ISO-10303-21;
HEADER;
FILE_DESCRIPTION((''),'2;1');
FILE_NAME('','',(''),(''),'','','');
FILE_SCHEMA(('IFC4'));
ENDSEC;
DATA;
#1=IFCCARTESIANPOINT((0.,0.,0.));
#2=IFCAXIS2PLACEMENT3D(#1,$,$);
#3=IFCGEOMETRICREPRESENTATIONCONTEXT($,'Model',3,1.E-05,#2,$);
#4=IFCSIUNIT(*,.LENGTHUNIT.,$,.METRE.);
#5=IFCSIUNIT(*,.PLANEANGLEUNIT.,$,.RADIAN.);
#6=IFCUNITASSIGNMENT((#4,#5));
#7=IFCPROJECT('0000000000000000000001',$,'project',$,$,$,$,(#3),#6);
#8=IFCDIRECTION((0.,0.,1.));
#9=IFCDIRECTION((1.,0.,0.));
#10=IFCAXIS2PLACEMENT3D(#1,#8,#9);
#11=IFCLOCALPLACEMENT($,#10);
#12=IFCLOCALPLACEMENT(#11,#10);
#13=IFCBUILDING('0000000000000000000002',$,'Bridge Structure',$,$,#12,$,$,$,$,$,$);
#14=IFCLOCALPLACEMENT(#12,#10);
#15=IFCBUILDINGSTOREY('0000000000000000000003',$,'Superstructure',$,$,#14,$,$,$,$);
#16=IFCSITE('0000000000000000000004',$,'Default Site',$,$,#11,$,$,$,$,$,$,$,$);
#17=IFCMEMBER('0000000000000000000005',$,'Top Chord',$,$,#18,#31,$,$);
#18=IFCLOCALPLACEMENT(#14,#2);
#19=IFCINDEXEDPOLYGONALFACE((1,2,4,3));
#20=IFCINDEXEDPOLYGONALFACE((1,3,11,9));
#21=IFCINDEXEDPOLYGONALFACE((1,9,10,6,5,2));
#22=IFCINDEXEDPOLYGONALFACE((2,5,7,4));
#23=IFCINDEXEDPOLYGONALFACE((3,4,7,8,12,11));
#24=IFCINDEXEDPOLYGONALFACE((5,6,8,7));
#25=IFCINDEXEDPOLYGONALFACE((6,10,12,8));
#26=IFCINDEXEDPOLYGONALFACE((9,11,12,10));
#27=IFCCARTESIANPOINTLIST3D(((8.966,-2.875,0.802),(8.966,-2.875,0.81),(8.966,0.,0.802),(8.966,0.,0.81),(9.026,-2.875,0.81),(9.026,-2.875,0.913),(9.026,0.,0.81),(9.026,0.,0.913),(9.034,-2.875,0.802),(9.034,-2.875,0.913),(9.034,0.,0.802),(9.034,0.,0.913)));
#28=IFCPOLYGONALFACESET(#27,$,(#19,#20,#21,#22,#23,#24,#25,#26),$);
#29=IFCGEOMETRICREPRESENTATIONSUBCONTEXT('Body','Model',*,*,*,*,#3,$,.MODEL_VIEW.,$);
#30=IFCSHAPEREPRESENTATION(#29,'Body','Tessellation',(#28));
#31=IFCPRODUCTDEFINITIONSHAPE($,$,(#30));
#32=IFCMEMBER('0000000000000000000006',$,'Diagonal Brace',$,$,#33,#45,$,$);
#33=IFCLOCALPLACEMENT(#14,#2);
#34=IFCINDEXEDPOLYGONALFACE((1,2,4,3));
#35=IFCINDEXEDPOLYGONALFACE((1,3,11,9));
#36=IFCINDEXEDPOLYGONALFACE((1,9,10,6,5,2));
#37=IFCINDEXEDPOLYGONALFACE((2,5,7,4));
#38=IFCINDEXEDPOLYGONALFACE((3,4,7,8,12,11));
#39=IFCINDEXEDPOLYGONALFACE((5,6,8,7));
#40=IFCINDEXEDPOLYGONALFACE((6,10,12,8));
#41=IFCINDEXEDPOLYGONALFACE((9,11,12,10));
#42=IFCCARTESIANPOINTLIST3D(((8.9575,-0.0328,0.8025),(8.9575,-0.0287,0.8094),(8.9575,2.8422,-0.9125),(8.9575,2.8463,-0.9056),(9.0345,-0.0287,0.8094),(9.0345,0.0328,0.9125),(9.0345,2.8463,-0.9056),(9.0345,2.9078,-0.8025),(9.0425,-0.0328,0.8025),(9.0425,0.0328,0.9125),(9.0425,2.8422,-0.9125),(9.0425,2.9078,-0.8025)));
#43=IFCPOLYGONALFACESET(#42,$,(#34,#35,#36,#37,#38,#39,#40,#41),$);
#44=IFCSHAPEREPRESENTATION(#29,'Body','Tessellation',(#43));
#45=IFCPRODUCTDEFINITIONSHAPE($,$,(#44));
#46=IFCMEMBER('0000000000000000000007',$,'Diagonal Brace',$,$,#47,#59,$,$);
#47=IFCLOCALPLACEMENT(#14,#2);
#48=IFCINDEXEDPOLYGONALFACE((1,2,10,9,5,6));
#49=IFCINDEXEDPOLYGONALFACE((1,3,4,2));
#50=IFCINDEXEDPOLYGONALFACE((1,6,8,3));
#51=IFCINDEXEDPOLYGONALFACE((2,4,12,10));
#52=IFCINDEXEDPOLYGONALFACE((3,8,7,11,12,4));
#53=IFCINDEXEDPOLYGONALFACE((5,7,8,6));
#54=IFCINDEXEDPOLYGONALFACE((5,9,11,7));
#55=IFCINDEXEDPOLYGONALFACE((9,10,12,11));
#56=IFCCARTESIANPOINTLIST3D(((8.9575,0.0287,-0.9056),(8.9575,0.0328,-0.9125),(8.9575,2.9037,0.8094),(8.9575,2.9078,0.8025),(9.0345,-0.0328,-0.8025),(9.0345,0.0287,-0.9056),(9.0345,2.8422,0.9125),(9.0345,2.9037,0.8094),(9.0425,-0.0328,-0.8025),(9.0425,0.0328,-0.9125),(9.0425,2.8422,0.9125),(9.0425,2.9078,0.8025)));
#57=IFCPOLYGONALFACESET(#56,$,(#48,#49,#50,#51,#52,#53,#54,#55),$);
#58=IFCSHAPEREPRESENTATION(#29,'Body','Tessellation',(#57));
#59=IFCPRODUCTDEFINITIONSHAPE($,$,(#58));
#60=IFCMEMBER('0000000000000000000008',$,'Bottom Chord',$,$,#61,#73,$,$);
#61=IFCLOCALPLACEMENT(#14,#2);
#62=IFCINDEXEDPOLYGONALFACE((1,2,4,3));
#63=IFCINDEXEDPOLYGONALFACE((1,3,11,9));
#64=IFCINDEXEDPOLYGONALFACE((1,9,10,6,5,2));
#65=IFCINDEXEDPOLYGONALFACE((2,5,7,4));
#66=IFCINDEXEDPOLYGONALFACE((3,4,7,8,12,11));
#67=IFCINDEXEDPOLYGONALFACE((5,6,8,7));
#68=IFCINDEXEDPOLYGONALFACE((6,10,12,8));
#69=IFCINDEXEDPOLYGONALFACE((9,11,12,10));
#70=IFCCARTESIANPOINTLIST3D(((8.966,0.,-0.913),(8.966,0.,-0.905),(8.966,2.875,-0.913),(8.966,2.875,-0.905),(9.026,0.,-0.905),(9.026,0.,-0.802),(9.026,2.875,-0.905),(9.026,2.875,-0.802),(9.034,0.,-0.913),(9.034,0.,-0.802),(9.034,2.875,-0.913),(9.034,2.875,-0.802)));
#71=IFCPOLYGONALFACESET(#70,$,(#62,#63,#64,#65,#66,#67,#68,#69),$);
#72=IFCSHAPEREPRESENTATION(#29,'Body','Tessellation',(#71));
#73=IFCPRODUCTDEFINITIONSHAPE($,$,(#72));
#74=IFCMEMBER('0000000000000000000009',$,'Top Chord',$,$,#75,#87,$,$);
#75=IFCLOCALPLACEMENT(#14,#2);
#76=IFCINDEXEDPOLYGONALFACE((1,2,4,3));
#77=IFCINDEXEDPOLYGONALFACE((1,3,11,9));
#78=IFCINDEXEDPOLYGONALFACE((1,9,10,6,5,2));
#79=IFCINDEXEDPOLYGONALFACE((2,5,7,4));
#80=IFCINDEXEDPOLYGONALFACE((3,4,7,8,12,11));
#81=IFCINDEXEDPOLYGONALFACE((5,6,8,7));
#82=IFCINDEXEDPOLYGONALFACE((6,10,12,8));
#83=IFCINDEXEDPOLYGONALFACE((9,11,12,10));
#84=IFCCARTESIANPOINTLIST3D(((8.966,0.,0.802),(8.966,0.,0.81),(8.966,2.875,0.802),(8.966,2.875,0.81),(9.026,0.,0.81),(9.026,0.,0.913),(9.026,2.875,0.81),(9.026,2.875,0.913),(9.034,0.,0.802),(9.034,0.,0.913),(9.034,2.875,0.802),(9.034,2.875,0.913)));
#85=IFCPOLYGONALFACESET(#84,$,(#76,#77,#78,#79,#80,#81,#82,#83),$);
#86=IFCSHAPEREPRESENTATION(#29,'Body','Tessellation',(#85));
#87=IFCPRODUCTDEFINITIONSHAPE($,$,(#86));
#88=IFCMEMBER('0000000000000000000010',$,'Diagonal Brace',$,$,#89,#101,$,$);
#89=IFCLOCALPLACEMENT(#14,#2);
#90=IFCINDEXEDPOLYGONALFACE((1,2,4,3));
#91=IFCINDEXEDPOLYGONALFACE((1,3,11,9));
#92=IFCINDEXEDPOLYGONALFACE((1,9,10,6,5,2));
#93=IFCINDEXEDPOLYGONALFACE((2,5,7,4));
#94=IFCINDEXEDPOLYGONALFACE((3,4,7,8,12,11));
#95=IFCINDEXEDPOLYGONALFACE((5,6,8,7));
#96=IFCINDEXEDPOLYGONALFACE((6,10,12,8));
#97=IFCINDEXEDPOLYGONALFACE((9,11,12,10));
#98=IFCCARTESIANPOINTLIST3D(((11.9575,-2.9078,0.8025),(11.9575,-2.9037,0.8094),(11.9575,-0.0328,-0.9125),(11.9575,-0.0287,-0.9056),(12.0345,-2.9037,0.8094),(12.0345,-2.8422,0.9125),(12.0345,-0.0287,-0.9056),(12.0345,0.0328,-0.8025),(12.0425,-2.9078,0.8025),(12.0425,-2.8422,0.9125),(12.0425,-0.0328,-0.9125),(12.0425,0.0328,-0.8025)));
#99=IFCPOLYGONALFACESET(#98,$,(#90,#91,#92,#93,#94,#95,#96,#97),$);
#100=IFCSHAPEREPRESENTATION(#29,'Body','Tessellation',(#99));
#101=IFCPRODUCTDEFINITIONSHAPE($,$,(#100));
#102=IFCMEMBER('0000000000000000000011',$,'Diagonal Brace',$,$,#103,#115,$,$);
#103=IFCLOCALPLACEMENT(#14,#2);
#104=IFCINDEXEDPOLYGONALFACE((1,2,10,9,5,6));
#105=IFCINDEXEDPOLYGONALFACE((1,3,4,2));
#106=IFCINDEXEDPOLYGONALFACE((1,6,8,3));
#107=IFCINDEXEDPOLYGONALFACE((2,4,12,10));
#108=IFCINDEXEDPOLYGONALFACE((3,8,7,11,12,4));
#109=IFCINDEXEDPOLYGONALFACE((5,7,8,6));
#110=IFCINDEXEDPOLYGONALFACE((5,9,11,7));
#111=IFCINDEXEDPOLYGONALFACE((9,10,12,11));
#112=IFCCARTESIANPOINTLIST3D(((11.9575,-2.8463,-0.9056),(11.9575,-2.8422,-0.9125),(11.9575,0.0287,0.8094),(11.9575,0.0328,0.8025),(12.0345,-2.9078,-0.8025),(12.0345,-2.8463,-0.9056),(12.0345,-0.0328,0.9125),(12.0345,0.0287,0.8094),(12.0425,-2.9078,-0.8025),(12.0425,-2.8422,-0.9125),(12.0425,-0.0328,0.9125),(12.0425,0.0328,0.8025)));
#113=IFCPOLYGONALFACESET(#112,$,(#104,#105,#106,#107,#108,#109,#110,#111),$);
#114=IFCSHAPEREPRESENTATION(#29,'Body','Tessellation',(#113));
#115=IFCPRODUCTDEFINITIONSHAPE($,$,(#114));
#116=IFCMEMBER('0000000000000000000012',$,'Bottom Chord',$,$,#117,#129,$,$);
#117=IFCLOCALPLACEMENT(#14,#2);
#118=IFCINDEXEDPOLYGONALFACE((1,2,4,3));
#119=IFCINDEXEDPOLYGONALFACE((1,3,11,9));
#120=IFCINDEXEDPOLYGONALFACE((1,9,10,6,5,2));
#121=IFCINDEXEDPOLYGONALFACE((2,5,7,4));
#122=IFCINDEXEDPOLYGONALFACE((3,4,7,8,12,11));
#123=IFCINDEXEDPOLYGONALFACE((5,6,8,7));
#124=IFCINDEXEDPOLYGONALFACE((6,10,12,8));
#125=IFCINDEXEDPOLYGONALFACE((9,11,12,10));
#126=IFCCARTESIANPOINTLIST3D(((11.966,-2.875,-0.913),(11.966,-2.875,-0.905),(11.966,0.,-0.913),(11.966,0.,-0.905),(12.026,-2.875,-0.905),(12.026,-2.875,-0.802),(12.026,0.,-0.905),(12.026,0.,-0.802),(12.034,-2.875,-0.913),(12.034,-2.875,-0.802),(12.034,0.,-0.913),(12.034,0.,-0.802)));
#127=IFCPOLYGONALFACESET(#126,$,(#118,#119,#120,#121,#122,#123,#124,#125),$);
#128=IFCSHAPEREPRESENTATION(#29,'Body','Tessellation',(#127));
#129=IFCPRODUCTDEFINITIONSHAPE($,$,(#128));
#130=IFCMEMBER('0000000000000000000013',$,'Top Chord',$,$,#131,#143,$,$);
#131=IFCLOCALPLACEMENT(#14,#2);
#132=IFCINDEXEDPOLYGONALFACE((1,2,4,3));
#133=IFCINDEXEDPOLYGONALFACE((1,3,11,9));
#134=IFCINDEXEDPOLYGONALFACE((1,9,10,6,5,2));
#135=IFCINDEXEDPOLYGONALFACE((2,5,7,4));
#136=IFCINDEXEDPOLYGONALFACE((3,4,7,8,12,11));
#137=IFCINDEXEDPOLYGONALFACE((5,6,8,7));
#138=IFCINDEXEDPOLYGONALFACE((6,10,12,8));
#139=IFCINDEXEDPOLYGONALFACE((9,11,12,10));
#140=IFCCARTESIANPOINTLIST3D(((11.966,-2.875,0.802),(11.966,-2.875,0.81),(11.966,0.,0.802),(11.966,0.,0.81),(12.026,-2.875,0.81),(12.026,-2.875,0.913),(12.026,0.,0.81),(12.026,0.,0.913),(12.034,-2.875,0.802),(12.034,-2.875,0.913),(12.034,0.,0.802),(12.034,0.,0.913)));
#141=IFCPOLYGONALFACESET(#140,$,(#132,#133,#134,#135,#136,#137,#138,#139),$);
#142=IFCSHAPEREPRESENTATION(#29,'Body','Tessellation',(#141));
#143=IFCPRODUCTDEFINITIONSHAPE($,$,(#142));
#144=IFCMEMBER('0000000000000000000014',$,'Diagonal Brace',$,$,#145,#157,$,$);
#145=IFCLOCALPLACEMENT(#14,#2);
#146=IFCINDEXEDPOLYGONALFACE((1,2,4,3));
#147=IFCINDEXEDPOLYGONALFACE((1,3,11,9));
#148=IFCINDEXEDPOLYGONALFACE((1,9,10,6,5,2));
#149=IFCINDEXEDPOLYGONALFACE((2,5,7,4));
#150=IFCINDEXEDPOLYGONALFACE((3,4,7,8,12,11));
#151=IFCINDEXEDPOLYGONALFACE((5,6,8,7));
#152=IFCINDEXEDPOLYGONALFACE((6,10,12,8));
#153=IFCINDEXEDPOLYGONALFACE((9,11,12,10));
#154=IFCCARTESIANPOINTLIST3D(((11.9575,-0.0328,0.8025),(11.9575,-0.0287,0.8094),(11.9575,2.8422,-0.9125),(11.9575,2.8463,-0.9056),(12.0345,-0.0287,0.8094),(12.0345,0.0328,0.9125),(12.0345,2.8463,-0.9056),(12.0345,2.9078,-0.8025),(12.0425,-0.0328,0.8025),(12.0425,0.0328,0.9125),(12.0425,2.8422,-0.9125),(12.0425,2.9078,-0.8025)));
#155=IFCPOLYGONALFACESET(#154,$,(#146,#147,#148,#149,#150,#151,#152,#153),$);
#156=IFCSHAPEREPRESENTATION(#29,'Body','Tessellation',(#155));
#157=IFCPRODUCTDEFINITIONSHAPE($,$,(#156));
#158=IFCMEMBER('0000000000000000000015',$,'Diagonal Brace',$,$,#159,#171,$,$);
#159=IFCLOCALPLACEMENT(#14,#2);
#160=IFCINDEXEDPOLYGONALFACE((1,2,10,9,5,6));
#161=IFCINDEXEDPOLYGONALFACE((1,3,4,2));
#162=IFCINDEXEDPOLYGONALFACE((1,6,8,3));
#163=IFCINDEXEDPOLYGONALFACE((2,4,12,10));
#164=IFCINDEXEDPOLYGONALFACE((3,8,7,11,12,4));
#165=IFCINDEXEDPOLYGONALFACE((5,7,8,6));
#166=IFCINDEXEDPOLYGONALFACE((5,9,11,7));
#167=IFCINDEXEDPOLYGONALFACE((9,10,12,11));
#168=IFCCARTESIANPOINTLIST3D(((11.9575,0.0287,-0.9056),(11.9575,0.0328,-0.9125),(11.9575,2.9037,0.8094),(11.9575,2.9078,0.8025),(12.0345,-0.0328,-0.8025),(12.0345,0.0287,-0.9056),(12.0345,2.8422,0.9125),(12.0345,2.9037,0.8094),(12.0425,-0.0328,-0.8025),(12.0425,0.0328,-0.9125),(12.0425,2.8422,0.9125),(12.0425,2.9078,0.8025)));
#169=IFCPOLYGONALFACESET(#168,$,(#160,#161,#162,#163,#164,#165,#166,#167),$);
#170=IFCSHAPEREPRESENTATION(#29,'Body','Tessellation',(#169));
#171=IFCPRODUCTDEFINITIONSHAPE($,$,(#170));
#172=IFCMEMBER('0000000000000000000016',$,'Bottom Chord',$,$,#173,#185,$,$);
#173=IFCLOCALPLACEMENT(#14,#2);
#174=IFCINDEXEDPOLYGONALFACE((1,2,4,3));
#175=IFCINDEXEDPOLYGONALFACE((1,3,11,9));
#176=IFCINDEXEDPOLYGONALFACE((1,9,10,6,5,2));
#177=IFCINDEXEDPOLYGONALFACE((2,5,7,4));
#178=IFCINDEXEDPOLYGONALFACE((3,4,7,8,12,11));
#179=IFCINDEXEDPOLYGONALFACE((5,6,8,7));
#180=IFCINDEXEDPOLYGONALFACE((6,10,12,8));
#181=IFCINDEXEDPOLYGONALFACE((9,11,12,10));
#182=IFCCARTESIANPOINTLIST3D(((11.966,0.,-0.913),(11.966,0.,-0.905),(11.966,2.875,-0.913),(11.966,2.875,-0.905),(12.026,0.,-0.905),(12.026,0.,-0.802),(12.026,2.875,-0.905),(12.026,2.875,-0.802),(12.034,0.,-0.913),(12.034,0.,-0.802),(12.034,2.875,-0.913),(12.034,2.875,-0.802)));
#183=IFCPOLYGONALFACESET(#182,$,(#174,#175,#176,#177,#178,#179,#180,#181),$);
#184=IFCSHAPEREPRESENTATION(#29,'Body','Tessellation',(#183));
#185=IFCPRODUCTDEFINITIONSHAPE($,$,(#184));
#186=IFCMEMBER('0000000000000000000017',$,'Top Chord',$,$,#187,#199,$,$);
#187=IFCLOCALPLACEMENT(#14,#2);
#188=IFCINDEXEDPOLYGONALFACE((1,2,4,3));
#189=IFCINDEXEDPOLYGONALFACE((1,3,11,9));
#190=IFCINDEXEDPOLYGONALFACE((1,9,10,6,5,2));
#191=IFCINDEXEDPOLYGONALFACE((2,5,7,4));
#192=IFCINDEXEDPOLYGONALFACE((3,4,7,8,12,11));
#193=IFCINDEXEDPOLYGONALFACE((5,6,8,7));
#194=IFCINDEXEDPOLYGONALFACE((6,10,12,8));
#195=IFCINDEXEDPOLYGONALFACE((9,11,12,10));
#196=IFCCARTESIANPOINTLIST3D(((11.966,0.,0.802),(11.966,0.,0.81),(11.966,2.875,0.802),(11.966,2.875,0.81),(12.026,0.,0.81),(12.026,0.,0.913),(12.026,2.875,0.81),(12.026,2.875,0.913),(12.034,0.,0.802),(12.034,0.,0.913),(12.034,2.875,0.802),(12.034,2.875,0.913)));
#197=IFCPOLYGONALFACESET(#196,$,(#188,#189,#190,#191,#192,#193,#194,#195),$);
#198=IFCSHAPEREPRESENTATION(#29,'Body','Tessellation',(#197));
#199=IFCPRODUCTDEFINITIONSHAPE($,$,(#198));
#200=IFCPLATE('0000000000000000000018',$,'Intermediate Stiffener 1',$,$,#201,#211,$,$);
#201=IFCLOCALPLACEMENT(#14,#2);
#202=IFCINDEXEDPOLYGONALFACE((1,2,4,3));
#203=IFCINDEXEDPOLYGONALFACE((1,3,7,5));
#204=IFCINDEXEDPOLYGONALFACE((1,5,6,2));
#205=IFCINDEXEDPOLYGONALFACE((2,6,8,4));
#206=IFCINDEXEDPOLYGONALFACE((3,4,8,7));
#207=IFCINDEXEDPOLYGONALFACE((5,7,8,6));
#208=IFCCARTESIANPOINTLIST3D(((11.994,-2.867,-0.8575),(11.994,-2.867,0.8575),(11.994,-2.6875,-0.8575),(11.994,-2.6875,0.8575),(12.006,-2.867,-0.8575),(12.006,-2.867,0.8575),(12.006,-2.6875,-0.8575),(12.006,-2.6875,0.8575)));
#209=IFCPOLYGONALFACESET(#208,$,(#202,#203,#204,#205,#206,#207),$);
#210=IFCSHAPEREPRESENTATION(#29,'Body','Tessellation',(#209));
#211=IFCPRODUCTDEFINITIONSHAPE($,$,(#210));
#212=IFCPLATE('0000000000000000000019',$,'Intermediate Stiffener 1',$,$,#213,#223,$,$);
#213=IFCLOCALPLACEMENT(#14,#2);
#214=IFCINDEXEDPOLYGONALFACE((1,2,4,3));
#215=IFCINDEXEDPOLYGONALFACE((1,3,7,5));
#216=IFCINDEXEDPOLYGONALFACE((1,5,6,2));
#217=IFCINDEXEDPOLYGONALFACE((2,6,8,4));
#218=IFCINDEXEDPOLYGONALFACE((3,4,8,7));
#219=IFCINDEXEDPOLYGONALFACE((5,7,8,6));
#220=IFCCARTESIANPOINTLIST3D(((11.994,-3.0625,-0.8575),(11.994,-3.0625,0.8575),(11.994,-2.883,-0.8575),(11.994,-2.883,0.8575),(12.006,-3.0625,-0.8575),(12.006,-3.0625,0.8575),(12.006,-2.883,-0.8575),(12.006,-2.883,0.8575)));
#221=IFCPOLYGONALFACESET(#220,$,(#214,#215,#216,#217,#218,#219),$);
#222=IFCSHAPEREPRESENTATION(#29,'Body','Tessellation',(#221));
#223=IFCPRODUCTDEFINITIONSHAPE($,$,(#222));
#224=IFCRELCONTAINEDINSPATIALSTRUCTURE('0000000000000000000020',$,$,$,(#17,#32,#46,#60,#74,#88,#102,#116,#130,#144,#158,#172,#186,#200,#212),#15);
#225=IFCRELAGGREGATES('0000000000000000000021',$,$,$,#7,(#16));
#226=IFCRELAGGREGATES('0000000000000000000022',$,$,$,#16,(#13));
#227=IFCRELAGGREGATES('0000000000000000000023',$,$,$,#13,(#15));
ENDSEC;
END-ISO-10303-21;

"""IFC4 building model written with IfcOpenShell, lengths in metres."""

from ifc_helpers import new_model, si_unit, frame, origin, origin_with_axes, origin_2d_with_axis, place, context, subcontext, project, spatial, rectangle, l_section, extrude, element, save


model = new_model("IFC4")

# Units and contexts
model_context = context("Model", 3, precision=1e-05, world=origin())
body_context = subcontext(model_context, "Body", "Model", "MODEL_VIEW")
ifc_project = project(units=[si_unit("LENGTHUNIT", "METRE"), si_unit("PLANEANGLEUNIT", "RADIAN")], contexts=[model_context])

# Site, building, storey
site_placement = place(None, origin_with_axes())
site = spatial("IfcSite", under=ifc_project, at=site_placement, Name="Default Site")
building_placement = place(site_placement, origin_with_axes())
building = spatial("IfcBuilding", under=site, at=building_placement, Name="Bridge Structure")
storey_placement = place(building_placement, origin_with_axes())
storey = spatial("IfcBuildingStorey", under=building, at=storey_placement, Name="Superstructure")

# Members
member_placement = place(storey_placement, frame((9.0, -2.875, 0.8575), z_axis=(0.0, 1.0, 0.0), x_axis=(-1.0, 0.0, 0.0)))
element("IfcMember", 1, at=member_placement, inside=storey, Name="Top Chord", context=body_context, shape_type="SweptSolid", body=[
    extrude(l_section(Depth=0.111, Width=0.068, Thickness=0.008, at=origin_2d_with_axis()), origin_with_axes(), (0.0, 0.0, 1.0), 2.875),
])
for number, where, z_axis, x_axis, name in (
    (2, (9.0, 0.0, 0.8575), (0.0, 0.858808, -0.512298), (-1.0, 0.0, 0.0), "Diagonal Brace"),
    (3, (9.0, 0.0, -0.8575), (0.0, 0.858808, 0.512298), (-1.0, 0.0, 0.0), "Diagonal Brace"),
):
    element("IfcMember", number, at=place(storey_placement, frame(where, z_axis=z_axis, x_axis=x_axis)), inside=storey, Name=name, context=body_context, shape_type="SweptSolid", body=[
        extrude(l_section(Depth=0.128, Width=0.085, Thickness=0.008, at=origin_2d_with_axis()), origin_with_axes(), (0.0, 0.0, 1.0), 3.3477),
    ])
for number, where, z_axis, x_axis, name in (
    (4, (9.0, 0.0, -0.8575), (0.0, 1.0, 0.0), (-1.0, 0.0, 0.0), "Bottom Chord"),
    (5, (9.0, 0.0, 0.8575), (0.0, 1.0, 0.0), (-1.0, 0.0, 0.0), "Top Chord"),
):
    element("IfcMember", number, at=place(storey_placement, frame(where, z_axis=z_axis, x_axis=x_axis)), inside=storey, Name=name, context=body_context, shape_type="SweptSolid", body=[
        extrude(l_section(Depth=0.111, Width=0.068, Thickness=0.008, at=origin_2d_with_axis()), origin_with_axes(), (0.0, 0.0, 1.0), 2.875),
    ])
for number, where, z_axis, x_axis, name in (
    (6, (12.0, -2.875, 0.8575), (0.0, 0.858808, -0.512298), (-1.0, 0.0, 0.0), "Diagonal Brace"),
    (7, (12.0, -2.875, -0.8575), (0.0, 0.858808, 0.512298), (-1.0, 0.0, 0.0), "Diagonal Brace"),
):
    element("IfcMember", number, at=place(storey_placement, frame(where, z_axis=z_axis, x_axis=x_axis)), inside=storey, Name=name, context=body_context, shape_type="SweptSolid", body=[
        extrude(l_section(Depth=0.128, Width=0.085, Thickness=0.008, at=origin_2d_with_axis()), origin_with_axes(), (0.0, 0.0, 1.0), 3.3477),
    ])
for number, where, z_axis, x_axis, name in (
    (8, (12.0, -2.875, -0.8575), (0.0, 1.0, 0.0), (-1.0, 0.0, 0.0), "Bottom Chord"),
    (9, (12.0, -2.875, 0.8575), (0.0, 1.0, 0.0), (-1.0, 0.0, 0.0), "Top Chord"),
):
    element("IfcMember", number, at=place(storey_placement, frame(where, z_axis=z_axis, x_axis=x_axis)), inside=storey, Name=name, context=body_context, shape_type="SweptSolid", body=[
        extrude(l_section(Depth=0.111, Width=0.068, Thickness=0.008, at=origin_2d_with_axis()), origin_with_axes(), (0.0, 0.0, 1.0), 2.875),
    ])
for number, where, z_axis, x_axis, name in (
    (10, (12.0, 0.0, 0.8575), (0.0, 0.858808, -0.512298), (-1.0, 0.0, 0.0), "Diagonal Brace"),
    (11, (12.0, 0.0, -0.8575), (0.0, 0.858808, 0.512298), (-1.0, 0.0, 0.0), "Diagonal Brace"),
):
    element("IfcMember", number, at=place(storey_placement, frame(where, z_axis=z_axis, x_axis=x_axis)), inside=storey, Name=name, context=body_context, shape_type="SweptSolid", body=[
        extrude(l_section(Depth=0.128, Width=0.085, Thickness=0.008, at=origin_2d_with_axis()), origin_with_axes(), (0.0, 0.0, 1.0), 3.3477),
    ])
for number, where, z_axis, x_axis, name in (
    (12, (12.0, 0.0, -0.8575), (0.0, 1.0, 0.0), (-1.0, 0.0, 0.0), "Bottom Chord"),
    (13, (12.0, 0.0, 0.8575), (0.0, 1.0, 0.0), (-1.0, 0.0, 0.0), "Top Chord"),
):
    element("IfcMember", number, at=place(storey_placement, frame(where, z_axis=z_axis, x_axis=x_axis)), inside=storey, Name=name, context=body_context, shape_type="SweptSolid", body=[
        extrude(l_section(Depth=0.111, Width=0.068, Thickness=0.008, at=origin_2d_with_axis()), origin_with_axes(), (0.0, 0.0, 1.0), 2.875),
    ])

# Plates
for number, where, z_axis, x_axis, name in (
    (14, (12.0, -2.7772, -0.8575), (0.0, 0.0, 1.0), (1.0, 0.0, 0.0), "Intermediate Stiffener 1"),
    (15, (12.0, -2.9728, -0.8575), (0.0, 0.0, 1.0), (1.0, 0.0, 0.0), "Intermediate Stiffener 1"),
):
    element("IfcPlate", number, at=place(storey_placement, frame(where, z_axis=z_axis, x_axis=x_axis)), inside=storey, Name=name, context=body_context, shape_type="SweptSolid", body=[
        extrude(rectangle(XDim=0.012, YDim=0.1795, at=origin_2d_with_axis()), origin_with_axes(), (0.0, 0.0, 1.0), 1.715),
    ])

save(model, "model.ifc")
